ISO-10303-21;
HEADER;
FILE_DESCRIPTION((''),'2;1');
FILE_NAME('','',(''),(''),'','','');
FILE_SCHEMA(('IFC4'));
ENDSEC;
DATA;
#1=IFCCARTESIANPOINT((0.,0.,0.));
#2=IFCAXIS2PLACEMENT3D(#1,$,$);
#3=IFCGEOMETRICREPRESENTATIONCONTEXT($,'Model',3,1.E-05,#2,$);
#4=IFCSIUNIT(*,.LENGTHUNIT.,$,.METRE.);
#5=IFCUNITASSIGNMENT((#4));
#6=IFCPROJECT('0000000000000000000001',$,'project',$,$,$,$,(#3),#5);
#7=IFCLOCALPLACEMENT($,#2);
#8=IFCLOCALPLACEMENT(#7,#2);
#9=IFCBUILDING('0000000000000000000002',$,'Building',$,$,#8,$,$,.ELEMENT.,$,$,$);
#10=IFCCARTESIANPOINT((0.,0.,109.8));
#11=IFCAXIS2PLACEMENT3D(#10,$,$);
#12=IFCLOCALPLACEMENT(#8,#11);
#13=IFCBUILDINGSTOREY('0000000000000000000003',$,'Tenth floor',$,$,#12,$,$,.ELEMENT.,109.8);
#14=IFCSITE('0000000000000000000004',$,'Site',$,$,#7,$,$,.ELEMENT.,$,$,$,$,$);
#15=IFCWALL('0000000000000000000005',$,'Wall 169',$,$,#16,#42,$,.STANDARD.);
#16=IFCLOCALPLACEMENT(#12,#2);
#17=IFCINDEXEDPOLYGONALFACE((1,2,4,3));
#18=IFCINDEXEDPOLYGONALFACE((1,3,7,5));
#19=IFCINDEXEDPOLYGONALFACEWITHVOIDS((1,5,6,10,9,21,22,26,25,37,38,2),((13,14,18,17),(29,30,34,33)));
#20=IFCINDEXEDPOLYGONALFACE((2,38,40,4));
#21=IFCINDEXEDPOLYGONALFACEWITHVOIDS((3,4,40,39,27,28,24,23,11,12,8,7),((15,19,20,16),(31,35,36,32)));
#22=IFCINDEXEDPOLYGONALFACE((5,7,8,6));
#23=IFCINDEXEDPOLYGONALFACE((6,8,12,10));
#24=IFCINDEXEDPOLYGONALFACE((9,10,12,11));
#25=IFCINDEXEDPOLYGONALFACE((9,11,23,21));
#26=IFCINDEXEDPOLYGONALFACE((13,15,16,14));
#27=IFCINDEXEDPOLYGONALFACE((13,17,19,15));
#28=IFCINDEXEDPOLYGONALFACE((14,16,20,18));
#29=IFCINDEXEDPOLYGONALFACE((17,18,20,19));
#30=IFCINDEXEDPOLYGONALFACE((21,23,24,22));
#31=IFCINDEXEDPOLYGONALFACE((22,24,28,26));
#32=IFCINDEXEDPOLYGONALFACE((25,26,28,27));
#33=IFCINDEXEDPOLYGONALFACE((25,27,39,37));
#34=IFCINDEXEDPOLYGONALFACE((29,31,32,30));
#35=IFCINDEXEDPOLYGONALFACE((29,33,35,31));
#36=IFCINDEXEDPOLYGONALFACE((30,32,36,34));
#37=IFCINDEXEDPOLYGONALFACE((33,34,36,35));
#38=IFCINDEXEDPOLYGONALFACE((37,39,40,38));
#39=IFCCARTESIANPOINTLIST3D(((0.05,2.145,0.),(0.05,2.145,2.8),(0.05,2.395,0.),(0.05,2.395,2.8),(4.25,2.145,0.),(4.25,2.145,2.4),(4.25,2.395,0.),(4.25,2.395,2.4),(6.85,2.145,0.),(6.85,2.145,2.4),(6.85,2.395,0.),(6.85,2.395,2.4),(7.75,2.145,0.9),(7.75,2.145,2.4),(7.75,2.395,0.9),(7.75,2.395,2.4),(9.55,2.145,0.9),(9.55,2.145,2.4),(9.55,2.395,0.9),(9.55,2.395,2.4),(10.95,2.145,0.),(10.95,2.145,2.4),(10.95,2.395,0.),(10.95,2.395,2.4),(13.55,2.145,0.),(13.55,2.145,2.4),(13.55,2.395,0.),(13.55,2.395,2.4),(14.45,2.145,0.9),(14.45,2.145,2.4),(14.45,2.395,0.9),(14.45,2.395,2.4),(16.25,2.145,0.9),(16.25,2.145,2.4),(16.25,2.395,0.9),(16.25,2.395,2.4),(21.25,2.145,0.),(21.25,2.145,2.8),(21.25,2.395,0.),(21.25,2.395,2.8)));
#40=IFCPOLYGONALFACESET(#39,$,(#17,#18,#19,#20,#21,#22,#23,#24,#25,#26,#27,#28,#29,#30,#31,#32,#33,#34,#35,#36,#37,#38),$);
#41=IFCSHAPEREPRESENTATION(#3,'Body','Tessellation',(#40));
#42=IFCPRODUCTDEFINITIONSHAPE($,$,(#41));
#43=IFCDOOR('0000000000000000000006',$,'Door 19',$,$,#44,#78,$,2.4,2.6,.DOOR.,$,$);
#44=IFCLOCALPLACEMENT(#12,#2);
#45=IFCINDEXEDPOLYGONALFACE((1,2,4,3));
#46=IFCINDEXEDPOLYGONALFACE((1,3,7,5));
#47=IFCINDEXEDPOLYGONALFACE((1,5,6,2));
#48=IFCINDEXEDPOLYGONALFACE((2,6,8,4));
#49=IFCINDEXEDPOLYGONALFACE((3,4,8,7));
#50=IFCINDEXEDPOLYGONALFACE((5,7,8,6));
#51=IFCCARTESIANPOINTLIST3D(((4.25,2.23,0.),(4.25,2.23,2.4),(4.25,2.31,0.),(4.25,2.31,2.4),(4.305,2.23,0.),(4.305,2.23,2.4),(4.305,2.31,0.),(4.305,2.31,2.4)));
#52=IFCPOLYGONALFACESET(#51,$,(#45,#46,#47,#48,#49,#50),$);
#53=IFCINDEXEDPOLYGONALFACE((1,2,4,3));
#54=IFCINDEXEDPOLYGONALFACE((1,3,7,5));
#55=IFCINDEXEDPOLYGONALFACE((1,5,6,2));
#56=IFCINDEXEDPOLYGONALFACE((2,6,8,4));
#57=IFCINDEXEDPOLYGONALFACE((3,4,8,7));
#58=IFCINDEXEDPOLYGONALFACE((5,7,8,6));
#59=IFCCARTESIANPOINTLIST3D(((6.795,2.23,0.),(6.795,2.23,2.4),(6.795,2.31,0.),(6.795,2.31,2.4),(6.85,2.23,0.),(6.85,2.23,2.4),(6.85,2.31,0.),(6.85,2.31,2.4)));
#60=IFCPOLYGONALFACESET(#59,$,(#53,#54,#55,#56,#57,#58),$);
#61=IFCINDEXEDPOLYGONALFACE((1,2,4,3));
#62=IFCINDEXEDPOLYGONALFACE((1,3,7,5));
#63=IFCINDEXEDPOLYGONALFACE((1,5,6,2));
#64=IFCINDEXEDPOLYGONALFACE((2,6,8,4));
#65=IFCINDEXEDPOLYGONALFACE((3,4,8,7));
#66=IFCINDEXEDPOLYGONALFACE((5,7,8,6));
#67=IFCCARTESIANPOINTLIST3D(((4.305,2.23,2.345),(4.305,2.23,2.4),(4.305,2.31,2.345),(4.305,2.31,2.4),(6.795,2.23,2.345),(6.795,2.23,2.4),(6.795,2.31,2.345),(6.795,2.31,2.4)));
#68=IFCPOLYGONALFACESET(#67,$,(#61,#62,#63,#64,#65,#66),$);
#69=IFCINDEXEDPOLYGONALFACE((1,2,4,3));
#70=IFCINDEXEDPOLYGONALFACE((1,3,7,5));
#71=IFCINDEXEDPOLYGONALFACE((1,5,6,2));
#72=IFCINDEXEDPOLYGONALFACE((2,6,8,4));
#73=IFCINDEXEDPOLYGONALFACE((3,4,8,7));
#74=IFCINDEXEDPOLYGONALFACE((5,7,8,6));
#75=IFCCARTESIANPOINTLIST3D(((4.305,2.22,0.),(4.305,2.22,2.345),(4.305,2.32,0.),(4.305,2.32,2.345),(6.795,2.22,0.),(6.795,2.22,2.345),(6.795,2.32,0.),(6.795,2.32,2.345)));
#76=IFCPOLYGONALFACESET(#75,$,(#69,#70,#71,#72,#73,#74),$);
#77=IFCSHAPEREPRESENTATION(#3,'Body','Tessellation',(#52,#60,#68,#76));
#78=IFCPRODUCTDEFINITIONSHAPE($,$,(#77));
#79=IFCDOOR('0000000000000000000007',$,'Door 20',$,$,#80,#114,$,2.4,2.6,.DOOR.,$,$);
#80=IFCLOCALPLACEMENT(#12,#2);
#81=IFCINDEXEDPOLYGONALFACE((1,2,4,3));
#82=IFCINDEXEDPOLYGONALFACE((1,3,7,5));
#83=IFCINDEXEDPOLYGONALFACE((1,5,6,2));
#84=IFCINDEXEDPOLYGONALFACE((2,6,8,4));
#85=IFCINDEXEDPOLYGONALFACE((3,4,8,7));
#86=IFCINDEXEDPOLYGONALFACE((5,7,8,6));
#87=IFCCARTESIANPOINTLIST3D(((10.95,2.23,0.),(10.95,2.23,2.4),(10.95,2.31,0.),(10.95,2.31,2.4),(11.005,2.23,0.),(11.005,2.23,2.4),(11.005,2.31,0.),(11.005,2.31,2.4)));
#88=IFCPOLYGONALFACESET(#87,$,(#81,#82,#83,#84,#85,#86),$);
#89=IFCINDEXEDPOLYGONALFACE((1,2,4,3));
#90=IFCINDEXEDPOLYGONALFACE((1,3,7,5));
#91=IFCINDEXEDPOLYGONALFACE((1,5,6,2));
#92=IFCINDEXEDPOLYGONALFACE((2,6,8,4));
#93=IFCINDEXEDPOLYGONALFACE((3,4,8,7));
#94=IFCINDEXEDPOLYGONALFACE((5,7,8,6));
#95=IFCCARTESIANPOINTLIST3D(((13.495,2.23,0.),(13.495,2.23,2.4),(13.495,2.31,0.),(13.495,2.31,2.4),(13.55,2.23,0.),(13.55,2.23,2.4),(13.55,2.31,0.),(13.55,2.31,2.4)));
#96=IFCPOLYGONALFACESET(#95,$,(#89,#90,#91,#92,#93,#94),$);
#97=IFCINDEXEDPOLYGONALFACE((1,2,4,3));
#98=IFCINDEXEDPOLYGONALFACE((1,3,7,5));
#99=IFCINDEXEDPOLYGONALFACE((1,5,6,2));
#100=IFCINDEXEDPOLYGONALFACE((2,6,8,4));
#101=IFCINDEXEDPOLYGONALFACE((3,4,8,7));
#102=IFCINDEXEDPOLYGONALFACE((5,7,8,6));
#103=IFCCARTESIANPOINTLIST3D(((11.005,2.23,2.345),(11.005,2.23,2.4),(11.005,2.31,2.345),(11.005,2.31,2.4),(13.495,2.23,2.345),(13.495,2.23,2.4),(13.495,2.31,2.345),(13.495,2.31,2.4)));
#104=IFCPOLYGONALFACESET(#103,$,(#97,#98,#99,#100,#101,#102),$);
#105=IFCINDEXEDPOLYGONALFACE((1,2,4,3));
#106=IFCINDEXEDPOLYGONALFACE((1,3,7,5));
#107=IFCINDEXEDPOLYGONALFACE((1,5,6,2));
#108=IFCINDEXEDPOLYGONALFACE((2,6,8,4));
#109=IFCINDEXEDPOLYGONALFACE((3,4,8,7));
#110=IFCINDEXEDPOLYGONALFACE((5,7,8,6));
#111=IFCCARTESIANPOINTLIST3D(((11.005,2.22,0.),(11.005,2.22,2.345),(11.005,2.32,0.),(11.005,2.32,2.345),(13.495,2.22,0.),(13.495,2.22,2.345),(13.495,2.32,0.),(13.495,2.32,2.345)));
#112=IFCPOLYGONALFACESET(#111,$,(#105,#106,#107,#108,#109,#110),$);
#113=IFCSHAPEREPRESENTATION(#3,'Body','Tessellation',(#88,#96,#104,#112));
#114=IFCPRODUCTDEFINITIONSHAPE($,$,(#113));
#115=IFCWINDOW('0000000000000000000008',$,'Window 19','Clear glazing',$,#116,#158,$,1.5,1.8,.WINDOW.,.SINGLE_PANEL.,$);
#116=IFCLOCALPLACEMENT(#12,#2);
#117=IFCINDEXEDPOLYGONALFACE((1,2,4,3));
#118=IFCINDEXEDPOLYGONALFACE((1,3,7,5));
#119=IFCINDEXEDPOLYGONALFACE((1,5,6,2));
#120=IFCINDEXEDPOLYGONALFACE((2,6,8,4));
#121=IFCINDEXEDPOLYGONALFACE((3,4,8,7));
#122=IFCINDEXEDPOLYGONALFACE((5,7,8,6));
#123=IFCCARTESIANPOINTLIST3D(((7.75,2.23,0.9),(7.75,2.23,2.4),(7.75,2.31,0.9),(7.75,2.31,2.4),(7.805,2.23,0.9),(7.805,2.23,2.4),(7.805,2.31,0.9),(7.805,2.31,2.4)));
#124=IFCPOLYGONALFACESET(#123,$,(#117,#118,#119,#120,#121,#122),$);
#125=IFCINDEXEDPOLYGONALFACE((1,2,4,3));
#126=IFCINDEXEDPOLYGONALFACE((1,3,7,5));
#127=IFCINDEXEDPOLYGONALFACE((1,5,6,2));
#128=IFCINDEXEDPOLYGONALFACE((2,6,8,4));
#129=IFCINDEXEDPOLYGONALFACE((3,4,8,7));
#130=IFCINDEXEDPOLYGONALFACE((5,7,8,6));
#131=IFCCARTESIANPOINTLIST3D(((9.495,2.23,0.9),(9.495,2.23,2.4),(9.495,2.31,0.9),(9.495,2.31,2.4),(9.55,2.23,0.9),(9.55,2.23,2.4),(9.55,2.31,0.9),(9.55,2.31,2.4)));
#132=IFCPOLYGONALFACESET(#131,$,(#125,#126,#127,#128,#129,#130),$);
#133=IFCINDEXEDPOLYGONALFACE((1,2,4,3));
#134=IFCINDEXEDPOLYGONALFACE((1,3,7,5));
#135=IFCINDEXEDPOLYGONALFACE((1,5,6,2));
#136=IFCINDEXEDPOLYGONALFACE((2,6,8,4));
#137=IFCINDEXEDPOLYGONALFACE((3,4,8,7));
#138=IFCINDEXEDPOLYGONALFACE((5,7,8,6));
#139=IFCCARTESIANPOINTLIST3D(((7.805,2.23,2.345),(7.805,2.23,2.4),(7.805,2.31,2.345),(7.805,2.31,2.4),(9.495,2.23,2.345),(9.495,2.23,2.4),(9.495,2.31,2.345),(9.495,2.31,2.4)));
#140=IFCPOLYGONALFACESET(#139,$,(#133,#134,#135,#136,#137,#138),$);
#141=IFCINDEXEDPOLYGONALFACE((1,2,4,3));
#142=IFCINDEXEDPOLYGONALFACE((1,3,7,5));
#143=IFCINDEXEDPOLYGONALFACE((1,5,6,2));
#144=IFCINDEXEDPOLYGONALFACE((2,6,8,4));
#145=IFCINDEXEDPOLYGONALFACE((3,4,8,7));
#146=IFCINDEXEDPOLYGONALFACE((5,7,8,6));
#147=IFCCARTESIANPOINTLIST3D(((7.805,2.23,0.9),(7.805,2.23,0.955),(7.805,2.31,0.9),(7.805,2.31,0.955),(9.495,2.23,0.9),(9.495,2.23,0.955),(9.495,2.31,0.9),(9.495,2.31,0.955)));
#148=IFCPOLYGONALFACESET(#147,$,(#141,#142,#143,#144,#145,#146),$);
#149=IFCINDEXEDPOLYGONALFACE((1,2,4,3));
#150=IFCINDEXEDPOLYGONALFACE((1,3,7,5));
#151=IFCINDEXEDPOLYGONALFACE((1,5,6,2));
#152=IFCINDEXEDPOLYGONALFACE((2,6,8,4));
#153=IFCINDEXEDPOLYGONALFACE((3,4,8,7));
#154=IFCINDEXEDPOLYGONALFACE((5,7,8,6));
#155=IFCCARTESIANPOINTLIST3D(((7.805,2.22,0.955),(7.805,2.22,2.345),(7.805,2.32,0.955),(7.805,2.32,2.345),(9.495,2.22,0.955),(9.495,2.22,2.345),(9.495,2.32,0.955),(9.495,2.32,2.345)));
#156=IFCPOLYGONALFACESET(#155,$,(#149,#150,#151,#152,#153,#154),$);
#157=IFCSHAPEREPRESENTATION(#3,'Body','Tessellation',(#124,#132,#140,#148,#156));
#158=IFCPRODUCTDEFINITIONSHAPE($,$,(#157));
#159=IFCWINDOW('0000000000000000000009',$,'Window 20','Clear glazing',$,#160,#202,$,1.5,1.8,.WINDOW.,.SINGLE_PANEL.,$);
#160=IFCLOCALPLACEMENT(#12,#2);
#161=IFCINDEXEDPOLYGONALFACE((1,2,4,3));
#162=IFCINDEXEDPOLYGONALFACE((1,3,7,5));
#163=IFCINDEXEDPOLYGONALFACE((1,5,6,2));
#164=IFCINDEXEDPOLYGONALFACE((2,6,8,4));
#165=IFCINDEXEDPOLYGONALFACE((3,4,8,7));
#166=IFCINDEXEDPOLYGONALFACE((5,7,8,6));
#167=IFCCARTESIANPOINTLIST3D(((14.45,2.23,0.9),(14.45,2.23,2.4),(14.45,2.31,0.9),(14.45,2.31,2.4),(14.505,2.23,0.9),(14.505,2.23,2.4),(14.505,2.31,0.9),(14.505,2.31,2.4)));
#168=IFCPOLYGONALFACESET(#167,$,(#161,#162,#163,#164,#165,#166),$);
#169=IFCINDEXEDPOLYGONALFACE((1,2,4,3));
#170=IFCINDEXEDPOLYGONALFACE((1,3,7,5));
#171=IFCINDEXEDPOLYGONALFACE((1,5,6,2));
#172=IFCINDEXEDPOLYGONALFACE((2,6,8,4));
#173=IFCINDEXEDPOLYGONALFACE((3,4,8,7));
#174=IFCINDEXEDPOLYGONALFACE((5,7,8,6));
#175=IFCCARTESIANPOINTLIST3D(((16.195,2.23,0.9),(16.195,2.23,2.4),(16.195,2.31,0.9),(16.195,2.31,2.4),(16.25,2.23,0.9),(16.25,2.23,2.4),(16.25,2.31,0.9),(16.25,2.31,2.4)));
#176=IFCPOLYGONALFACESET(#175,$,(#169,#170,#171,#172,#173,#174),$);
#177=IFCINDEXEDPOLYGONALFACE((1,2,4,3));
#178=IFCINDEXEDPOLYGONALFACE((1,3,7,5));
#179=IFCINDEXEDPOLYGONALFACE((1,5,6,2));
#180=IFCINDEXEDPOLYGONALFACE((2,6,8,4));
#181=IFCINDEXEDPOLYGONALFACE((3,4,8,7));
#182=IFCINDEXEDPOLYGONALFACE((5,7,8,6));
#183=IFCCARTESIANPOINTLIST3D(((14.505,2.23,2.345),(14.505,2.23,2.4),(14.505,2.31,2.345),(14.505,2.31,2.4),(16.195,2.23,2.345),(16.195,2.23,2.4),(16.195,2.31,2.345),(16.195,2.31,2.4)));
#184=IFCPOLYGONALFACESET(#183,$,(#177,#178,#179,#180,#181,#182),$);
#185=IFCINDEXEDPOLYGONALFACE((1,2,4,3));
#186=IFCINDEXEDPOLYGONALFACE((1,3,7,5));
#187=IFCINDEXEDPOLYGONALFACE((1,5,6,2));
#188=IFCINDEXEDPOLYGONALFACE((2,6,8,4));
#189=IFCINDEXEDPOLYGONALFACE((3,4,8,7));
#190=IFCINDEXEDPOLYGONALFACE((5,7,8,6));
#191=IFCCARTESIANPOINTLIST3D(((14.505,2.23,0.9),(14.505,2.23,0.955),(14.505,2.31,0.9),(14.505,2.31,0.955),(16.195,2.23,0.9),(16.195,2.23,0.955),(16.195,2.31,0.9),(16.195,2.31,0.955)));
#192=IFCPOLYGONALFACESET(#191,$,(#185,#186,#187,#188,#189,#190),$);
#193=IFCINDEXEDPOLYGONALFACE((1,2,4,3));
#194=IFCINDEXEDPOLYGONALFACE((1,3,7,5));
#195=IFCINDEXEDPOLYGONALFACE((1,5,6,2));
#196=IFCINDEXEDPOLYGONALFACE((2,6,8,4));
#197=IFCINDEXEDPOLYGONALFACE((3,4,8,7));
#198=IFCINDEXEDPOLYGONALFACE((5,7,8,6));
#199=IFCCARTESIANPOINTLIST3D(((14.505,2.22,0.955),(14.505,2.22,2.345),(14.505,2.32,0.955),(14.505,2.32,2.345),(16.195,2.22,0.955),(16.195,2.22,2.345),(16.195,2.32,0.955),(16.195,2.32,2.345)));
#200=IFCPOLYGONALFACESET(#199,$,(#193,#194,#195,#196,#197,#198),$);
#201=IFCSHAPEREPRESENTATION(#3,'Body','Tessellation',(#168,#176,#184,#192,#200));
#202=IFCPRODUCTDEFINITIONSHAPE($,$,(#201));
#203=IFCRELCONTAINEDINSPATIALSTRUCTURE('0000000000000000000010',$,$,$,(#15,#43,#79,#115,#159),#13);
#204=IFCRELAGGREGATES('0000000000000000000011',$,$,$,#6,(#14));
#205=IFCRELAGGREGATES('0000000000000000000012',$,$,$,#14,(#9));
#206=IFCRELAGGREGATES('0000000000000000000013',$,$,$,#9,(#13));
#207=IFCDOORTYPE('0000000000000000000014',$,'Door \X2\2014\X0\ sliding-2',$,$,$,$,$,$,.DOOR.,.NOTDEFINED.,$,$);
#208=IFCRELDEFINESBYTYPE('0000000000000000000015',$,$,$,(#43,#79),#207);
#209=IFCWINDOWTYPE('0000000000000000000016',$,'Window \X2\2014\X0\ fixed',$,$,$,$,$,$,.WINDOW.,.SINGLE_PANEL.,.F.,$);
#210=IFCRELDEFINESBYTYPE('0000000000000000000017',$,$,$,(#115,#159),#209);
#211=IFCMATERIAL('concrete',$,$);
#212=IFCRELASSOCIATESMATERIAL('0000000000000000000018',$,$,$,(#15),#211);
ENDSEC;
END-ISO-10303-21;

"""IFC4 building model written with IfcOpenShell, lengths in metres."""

from ifc_helpers import new_model, si_unit, frame, frame_2d, origin, place, context, project, spatial, rectangle, extrude, material, type_object, element, fill, save


model = new_model("IFC4")

# Units and contexts
model_context = context("Model", 3, precision=1e-05, world=origin())
ifc_project = project(units=[si_unit("LENGTHUNIT", "METRE")], contexts=[model_context])

# Site, building, storey
site_placement = place(None, origin())
site = spatial("IfcSite", under=ifc_project, at=site_placement, Name="Site", CompositionType="ELEMENT")
building_placement = place(site_placement, origin())
building = spatial("IfcBuilding", under=site, at=building_placement, Name="Building", CompositionType="ELEMENT")
storey_placement = place(building_placement, frame((0.0, 0.0, 109.8)))
storey = spatial("IfcBuildingStorey", under=building, at=storey_placement, Name="Tenth floor", CompositionType="ELEMENT", Elevation=109.8)

# Shared definitions
ifc_material = material(Name="concrete")

# Wall, openings, doors, windows
wall_1_placement = place(storey_placement, frame((0.05, 2.27, 0.0), z_axis=(0.0, 0.0, 1.0), x_axis=(1.0, 0.0, 0.0)))
wall_1 = element("IfcWall", 1, at=wall_1_placement, inside=storey, material=ifc_material, Name="Wall 169", PredefinedType="STANDARD", context=model_context, shape_type="SweptSolid", body=[
    extrude(rectangle(XDim=21.2, YDim=0.25, at=frame_2d((10.6, 0.0))), origin(), (0.0, 0.0, 1.0), 2.8),
])
opening_1_placement = place(storey_placement, frame((4.25, 2.27, 0.0), z_axis=(0.0, 0.0, 1.0), x_axis=(1.0, 0.0, 0.0)))
opening_1 = element("IfcOpeningElement", 2, at=opening_1_placement, cuts=wall_1, PredefinedType="OPENING", context=model_context, shape_type="SweptSolid", body=[
    extrude(rectangle(XDim=2.6, YDim=0.31, at=frame_2d((1.3, 0.0))), origin(), (0.0, 0.0, 1.0), 2.4),
])
opening_2_placement = place(storey_placement, frame((7.75, 2.27, 0.9), z_axis=(0.0, 0.0, 1.0), x_axis=(1.0, 0.0, 0.0)))
opening_2 = element("IfcOpeningElement", 3, at=opening_2_placement, cuts=wall_1, PredefinedType="OPENING", context=model_context, shape_type="SweptSolid", body=[
    extrude(rectangle(XDim=1.8, YDim=0.31, at=frame_2d((0.9, 0.0))), origin(), (0.0, 0.0, 1.0), 1.5),
])
opening_3_placement = place(storey_placement, frame((10.95, 2.27, 0.0), z_axis=(0.0, 0.0, 1.0), x_axis=(1.0, 0.0, 0.0)))
opening_3 = element("IfcOpeningElement", 4, at=opening_3_placement, cuts=wall_1, PredefinedType="OPENING", context=model_context, shape_type="SweptSolid", body=[
    extrude(rectangle(XDim=2.6, YDim=0.31, at=frame_2d((1.3, 0.0))), origin(), (0.0, 0.0, 1.0), 2.4),
])
opening_4_placement = place(storey_placement, frame((14.45, 2.27, 0.9), z_axis=(0.0, 0.0, 1.0), x_axis=(1.0, 0.0, 0.0)))
opening_4 = element("IfcOpeningElement", 5, at=opening_4_placement, cuts=wall_1, PredefinedType="OPENING", context=model_context, shape_type="SweptSolid", body=[
    extrude(rectangle(XDim=1.8, YDim=0.31, at=frame_2d((0.9, 0.0))), origin(), (0.0, 0.0, 1.0), 1.5),
])
door_type = type_object("IfcDoorType", Name="Door — sliding-2", PredefinedType="DOOR")
door_1_placement = place(storey_placement, frame((4.25, 2.27, 0.0), z_axis=(0.0, 0.0, 1.0), x_axis=(1.0, 0.0, 0.0)))
door_1 = element("IfcDoor", 6, at=door_1_placement, inside=storey, type_object=door_type, Name="Door 19", OverallHeight=2.4, OverallWidth=2.6, PredefinedType="DOOR", context=model_context, shape_type="SweptSolid", body=[
    extrude(rectangle(XDim=0.055, YDim=0.08, at=frame_2d((0.0275, 0.0))), origin(), (0.0, 0.0, 1.0), 2.4),
    extrude(rectangle(XDim=0.055, YDim=0.08, at=frame_2d((2.5725, 0.0))), origin(), (0.0, 0.0, 1.0), 2.4),
    extrude(rectangle(XDim=2.49, YDim=0.08, at=frame_2d((1.3, 0.0))), frame((0.0, 0.0, 2.345)), (0.0, 0.0, 1.0), 0.055),
    extrude(rectangle(XDim=2.49, YDim=0.1, at=frame_2d((1.3, 0.0))), origin(), (0.0, 0.0, 1.0), 2.345),
])
fill(opening_1, door_1)
door_2_placement = place(storey_placement, frame((10.95, 2.27, 0.0), z_axis=(0.0, 0.0, 1.0), x_axis=(1.0, 0.0, 0.0)))
door_2 = element("IfcDoor", 7, at=door_2_placement, inside=storey, type_object=door_type, Name="Door 20", OverallHeight=2.4, OverallWidth=2.6, PredefinedType="DOOR", context=model_context, shape_type="SweptSolid", body=[
    extrude(rectangle(XDim=0.055, YDim=0.08, at=frame_2d((0.0275, 0.0))), origin(), (0.0, 0.0, 1.0), 2.4),
    extrude(rectangle(XDim=0.055, YDim=0.08, at=frame_2d((2.5725, 0.0))), origin(), (0.0, 0.0, 1.0), 2.4),
    extrude(rectangle(XDim=2.49, YDim=0.08, at=frame_2d((1.3, 0.0))), frame((0.0, 0.0, 2.345)), (0.0, 0.0, 1.0), 0.055),
    extrude(rectangle(XDim=2.49, YDim=0.1, at=frame_2d((1.3, 0.0))), origin(), (0.0, 0.0, 1.0), 2.345),
])
fill(opening_3, door_2)
window_type = type_object("IfcWindowType", Name="Window — fixed", ParameterTakesPrecedence=False, PartitioningType="SINGLE_PANEL", PredefinedType="WINDOW")
window_1_placement = place(storey_placement, frame((7.75, 2.27, 0.9), z_axis=(0.0, 0.0, 1.0), x_axis=(1.0, 0.0, 0.0)))
window_1 = element("IfcWindow", 8, at=window_1_placement, inside=storey, type_object=window_type, Name="Window 19", Description="Clear glazing", OverallHeight=1.5, OverallWidth=1.8, PartitioningType="SINGLE_PANEL", PredefinedType="WINDOW", context=model_context, shape_type="SweptSolid", body=[
    extrude(rectangle(XDim=0.055, YDim=0.08, at=frame_2d((0.0275, 0.0))), origin(), (0.0, 0.0, 1.0), 1.5),
    extrude(rectangle(XDim=0.055, YDim=0.08, at=frame_2d((1.7725, 0.0))), origin(), (0.0, 0.0, 1.0), 1.5),
    extrude(rectangle(XDim=1.69, YDim=0.08, at=frame_2d((0.9, 0.0))), frame((0.0, 0.0, 1.445)), (0.0, 0.0, 1.0), 0.055),
    extrude(rectangle(XDim=1.69, YDim=0.08, at=frame_2d((0.9, 0.0))), origin(), (0.0, 0.0, 1.0), 0.055),
    extrude(rectangle(XDim=1.69, YDim=0.1, at=frame_2d((0.9, 0.0))), frame((0.0, 0.0, 0.055)), (0.0, 0.0, 1.0), 1.39),
])
fill(opening_2, window_1)
window_2_placement = place(storey_placement, frame((14.45, 2.27, 0.9), z_axis=(0.0, 0.0, 1.0), x_axis=(1.0, 0.0, 0.0)))
window_2 = element("IfcWindow", 9, at=window_2_placement, inside=storey, type_object=window_type, Name="Window 20", Description="Clear glazing", OverallHeight=1.5, OverallWidth=1.8, PartitioningType="SINGLE_PANEL", PredefinedType="WINDOW", context=model_context, shape_type="SweptSolid", body=[
    extrude(rectangle(XDim=0.055, YDim=0.08, at=frame_2d((0.0275, 0.0))), origin(), (0.0, 0.0, 1.0), 1.5),
    extrude(rectangle(XDim=0.055, YDim=0.08, at=frame_2d((1.7725, 0.0))), origin(), (0.0, 0.0, 1.0), 1.5),
    extrude(rectangle(XDim=1.69, YDim=0.08, at=frame_2d((0.9, 0.0))), frame((0.0, 0.0, 1.445)), (0.0, 0.0, 1.0), 0.055),
    extrude(rectangle(XDim=1.69, YDim=0.08, at=frame_2d((0.9, 0.0))), origin(), (0.0, 0.0, 1.0), 0.055),
    extrude(rectangle(XDim=1.69, YDim=0.1, at=frame_2d((0.9, 0.0))), frame((0.0, 0.0, 0.055)), (0.0, 0.0, 1.0), 1.39),
])
fill(opening_4, window_2)

save(model, "model.ifc")
